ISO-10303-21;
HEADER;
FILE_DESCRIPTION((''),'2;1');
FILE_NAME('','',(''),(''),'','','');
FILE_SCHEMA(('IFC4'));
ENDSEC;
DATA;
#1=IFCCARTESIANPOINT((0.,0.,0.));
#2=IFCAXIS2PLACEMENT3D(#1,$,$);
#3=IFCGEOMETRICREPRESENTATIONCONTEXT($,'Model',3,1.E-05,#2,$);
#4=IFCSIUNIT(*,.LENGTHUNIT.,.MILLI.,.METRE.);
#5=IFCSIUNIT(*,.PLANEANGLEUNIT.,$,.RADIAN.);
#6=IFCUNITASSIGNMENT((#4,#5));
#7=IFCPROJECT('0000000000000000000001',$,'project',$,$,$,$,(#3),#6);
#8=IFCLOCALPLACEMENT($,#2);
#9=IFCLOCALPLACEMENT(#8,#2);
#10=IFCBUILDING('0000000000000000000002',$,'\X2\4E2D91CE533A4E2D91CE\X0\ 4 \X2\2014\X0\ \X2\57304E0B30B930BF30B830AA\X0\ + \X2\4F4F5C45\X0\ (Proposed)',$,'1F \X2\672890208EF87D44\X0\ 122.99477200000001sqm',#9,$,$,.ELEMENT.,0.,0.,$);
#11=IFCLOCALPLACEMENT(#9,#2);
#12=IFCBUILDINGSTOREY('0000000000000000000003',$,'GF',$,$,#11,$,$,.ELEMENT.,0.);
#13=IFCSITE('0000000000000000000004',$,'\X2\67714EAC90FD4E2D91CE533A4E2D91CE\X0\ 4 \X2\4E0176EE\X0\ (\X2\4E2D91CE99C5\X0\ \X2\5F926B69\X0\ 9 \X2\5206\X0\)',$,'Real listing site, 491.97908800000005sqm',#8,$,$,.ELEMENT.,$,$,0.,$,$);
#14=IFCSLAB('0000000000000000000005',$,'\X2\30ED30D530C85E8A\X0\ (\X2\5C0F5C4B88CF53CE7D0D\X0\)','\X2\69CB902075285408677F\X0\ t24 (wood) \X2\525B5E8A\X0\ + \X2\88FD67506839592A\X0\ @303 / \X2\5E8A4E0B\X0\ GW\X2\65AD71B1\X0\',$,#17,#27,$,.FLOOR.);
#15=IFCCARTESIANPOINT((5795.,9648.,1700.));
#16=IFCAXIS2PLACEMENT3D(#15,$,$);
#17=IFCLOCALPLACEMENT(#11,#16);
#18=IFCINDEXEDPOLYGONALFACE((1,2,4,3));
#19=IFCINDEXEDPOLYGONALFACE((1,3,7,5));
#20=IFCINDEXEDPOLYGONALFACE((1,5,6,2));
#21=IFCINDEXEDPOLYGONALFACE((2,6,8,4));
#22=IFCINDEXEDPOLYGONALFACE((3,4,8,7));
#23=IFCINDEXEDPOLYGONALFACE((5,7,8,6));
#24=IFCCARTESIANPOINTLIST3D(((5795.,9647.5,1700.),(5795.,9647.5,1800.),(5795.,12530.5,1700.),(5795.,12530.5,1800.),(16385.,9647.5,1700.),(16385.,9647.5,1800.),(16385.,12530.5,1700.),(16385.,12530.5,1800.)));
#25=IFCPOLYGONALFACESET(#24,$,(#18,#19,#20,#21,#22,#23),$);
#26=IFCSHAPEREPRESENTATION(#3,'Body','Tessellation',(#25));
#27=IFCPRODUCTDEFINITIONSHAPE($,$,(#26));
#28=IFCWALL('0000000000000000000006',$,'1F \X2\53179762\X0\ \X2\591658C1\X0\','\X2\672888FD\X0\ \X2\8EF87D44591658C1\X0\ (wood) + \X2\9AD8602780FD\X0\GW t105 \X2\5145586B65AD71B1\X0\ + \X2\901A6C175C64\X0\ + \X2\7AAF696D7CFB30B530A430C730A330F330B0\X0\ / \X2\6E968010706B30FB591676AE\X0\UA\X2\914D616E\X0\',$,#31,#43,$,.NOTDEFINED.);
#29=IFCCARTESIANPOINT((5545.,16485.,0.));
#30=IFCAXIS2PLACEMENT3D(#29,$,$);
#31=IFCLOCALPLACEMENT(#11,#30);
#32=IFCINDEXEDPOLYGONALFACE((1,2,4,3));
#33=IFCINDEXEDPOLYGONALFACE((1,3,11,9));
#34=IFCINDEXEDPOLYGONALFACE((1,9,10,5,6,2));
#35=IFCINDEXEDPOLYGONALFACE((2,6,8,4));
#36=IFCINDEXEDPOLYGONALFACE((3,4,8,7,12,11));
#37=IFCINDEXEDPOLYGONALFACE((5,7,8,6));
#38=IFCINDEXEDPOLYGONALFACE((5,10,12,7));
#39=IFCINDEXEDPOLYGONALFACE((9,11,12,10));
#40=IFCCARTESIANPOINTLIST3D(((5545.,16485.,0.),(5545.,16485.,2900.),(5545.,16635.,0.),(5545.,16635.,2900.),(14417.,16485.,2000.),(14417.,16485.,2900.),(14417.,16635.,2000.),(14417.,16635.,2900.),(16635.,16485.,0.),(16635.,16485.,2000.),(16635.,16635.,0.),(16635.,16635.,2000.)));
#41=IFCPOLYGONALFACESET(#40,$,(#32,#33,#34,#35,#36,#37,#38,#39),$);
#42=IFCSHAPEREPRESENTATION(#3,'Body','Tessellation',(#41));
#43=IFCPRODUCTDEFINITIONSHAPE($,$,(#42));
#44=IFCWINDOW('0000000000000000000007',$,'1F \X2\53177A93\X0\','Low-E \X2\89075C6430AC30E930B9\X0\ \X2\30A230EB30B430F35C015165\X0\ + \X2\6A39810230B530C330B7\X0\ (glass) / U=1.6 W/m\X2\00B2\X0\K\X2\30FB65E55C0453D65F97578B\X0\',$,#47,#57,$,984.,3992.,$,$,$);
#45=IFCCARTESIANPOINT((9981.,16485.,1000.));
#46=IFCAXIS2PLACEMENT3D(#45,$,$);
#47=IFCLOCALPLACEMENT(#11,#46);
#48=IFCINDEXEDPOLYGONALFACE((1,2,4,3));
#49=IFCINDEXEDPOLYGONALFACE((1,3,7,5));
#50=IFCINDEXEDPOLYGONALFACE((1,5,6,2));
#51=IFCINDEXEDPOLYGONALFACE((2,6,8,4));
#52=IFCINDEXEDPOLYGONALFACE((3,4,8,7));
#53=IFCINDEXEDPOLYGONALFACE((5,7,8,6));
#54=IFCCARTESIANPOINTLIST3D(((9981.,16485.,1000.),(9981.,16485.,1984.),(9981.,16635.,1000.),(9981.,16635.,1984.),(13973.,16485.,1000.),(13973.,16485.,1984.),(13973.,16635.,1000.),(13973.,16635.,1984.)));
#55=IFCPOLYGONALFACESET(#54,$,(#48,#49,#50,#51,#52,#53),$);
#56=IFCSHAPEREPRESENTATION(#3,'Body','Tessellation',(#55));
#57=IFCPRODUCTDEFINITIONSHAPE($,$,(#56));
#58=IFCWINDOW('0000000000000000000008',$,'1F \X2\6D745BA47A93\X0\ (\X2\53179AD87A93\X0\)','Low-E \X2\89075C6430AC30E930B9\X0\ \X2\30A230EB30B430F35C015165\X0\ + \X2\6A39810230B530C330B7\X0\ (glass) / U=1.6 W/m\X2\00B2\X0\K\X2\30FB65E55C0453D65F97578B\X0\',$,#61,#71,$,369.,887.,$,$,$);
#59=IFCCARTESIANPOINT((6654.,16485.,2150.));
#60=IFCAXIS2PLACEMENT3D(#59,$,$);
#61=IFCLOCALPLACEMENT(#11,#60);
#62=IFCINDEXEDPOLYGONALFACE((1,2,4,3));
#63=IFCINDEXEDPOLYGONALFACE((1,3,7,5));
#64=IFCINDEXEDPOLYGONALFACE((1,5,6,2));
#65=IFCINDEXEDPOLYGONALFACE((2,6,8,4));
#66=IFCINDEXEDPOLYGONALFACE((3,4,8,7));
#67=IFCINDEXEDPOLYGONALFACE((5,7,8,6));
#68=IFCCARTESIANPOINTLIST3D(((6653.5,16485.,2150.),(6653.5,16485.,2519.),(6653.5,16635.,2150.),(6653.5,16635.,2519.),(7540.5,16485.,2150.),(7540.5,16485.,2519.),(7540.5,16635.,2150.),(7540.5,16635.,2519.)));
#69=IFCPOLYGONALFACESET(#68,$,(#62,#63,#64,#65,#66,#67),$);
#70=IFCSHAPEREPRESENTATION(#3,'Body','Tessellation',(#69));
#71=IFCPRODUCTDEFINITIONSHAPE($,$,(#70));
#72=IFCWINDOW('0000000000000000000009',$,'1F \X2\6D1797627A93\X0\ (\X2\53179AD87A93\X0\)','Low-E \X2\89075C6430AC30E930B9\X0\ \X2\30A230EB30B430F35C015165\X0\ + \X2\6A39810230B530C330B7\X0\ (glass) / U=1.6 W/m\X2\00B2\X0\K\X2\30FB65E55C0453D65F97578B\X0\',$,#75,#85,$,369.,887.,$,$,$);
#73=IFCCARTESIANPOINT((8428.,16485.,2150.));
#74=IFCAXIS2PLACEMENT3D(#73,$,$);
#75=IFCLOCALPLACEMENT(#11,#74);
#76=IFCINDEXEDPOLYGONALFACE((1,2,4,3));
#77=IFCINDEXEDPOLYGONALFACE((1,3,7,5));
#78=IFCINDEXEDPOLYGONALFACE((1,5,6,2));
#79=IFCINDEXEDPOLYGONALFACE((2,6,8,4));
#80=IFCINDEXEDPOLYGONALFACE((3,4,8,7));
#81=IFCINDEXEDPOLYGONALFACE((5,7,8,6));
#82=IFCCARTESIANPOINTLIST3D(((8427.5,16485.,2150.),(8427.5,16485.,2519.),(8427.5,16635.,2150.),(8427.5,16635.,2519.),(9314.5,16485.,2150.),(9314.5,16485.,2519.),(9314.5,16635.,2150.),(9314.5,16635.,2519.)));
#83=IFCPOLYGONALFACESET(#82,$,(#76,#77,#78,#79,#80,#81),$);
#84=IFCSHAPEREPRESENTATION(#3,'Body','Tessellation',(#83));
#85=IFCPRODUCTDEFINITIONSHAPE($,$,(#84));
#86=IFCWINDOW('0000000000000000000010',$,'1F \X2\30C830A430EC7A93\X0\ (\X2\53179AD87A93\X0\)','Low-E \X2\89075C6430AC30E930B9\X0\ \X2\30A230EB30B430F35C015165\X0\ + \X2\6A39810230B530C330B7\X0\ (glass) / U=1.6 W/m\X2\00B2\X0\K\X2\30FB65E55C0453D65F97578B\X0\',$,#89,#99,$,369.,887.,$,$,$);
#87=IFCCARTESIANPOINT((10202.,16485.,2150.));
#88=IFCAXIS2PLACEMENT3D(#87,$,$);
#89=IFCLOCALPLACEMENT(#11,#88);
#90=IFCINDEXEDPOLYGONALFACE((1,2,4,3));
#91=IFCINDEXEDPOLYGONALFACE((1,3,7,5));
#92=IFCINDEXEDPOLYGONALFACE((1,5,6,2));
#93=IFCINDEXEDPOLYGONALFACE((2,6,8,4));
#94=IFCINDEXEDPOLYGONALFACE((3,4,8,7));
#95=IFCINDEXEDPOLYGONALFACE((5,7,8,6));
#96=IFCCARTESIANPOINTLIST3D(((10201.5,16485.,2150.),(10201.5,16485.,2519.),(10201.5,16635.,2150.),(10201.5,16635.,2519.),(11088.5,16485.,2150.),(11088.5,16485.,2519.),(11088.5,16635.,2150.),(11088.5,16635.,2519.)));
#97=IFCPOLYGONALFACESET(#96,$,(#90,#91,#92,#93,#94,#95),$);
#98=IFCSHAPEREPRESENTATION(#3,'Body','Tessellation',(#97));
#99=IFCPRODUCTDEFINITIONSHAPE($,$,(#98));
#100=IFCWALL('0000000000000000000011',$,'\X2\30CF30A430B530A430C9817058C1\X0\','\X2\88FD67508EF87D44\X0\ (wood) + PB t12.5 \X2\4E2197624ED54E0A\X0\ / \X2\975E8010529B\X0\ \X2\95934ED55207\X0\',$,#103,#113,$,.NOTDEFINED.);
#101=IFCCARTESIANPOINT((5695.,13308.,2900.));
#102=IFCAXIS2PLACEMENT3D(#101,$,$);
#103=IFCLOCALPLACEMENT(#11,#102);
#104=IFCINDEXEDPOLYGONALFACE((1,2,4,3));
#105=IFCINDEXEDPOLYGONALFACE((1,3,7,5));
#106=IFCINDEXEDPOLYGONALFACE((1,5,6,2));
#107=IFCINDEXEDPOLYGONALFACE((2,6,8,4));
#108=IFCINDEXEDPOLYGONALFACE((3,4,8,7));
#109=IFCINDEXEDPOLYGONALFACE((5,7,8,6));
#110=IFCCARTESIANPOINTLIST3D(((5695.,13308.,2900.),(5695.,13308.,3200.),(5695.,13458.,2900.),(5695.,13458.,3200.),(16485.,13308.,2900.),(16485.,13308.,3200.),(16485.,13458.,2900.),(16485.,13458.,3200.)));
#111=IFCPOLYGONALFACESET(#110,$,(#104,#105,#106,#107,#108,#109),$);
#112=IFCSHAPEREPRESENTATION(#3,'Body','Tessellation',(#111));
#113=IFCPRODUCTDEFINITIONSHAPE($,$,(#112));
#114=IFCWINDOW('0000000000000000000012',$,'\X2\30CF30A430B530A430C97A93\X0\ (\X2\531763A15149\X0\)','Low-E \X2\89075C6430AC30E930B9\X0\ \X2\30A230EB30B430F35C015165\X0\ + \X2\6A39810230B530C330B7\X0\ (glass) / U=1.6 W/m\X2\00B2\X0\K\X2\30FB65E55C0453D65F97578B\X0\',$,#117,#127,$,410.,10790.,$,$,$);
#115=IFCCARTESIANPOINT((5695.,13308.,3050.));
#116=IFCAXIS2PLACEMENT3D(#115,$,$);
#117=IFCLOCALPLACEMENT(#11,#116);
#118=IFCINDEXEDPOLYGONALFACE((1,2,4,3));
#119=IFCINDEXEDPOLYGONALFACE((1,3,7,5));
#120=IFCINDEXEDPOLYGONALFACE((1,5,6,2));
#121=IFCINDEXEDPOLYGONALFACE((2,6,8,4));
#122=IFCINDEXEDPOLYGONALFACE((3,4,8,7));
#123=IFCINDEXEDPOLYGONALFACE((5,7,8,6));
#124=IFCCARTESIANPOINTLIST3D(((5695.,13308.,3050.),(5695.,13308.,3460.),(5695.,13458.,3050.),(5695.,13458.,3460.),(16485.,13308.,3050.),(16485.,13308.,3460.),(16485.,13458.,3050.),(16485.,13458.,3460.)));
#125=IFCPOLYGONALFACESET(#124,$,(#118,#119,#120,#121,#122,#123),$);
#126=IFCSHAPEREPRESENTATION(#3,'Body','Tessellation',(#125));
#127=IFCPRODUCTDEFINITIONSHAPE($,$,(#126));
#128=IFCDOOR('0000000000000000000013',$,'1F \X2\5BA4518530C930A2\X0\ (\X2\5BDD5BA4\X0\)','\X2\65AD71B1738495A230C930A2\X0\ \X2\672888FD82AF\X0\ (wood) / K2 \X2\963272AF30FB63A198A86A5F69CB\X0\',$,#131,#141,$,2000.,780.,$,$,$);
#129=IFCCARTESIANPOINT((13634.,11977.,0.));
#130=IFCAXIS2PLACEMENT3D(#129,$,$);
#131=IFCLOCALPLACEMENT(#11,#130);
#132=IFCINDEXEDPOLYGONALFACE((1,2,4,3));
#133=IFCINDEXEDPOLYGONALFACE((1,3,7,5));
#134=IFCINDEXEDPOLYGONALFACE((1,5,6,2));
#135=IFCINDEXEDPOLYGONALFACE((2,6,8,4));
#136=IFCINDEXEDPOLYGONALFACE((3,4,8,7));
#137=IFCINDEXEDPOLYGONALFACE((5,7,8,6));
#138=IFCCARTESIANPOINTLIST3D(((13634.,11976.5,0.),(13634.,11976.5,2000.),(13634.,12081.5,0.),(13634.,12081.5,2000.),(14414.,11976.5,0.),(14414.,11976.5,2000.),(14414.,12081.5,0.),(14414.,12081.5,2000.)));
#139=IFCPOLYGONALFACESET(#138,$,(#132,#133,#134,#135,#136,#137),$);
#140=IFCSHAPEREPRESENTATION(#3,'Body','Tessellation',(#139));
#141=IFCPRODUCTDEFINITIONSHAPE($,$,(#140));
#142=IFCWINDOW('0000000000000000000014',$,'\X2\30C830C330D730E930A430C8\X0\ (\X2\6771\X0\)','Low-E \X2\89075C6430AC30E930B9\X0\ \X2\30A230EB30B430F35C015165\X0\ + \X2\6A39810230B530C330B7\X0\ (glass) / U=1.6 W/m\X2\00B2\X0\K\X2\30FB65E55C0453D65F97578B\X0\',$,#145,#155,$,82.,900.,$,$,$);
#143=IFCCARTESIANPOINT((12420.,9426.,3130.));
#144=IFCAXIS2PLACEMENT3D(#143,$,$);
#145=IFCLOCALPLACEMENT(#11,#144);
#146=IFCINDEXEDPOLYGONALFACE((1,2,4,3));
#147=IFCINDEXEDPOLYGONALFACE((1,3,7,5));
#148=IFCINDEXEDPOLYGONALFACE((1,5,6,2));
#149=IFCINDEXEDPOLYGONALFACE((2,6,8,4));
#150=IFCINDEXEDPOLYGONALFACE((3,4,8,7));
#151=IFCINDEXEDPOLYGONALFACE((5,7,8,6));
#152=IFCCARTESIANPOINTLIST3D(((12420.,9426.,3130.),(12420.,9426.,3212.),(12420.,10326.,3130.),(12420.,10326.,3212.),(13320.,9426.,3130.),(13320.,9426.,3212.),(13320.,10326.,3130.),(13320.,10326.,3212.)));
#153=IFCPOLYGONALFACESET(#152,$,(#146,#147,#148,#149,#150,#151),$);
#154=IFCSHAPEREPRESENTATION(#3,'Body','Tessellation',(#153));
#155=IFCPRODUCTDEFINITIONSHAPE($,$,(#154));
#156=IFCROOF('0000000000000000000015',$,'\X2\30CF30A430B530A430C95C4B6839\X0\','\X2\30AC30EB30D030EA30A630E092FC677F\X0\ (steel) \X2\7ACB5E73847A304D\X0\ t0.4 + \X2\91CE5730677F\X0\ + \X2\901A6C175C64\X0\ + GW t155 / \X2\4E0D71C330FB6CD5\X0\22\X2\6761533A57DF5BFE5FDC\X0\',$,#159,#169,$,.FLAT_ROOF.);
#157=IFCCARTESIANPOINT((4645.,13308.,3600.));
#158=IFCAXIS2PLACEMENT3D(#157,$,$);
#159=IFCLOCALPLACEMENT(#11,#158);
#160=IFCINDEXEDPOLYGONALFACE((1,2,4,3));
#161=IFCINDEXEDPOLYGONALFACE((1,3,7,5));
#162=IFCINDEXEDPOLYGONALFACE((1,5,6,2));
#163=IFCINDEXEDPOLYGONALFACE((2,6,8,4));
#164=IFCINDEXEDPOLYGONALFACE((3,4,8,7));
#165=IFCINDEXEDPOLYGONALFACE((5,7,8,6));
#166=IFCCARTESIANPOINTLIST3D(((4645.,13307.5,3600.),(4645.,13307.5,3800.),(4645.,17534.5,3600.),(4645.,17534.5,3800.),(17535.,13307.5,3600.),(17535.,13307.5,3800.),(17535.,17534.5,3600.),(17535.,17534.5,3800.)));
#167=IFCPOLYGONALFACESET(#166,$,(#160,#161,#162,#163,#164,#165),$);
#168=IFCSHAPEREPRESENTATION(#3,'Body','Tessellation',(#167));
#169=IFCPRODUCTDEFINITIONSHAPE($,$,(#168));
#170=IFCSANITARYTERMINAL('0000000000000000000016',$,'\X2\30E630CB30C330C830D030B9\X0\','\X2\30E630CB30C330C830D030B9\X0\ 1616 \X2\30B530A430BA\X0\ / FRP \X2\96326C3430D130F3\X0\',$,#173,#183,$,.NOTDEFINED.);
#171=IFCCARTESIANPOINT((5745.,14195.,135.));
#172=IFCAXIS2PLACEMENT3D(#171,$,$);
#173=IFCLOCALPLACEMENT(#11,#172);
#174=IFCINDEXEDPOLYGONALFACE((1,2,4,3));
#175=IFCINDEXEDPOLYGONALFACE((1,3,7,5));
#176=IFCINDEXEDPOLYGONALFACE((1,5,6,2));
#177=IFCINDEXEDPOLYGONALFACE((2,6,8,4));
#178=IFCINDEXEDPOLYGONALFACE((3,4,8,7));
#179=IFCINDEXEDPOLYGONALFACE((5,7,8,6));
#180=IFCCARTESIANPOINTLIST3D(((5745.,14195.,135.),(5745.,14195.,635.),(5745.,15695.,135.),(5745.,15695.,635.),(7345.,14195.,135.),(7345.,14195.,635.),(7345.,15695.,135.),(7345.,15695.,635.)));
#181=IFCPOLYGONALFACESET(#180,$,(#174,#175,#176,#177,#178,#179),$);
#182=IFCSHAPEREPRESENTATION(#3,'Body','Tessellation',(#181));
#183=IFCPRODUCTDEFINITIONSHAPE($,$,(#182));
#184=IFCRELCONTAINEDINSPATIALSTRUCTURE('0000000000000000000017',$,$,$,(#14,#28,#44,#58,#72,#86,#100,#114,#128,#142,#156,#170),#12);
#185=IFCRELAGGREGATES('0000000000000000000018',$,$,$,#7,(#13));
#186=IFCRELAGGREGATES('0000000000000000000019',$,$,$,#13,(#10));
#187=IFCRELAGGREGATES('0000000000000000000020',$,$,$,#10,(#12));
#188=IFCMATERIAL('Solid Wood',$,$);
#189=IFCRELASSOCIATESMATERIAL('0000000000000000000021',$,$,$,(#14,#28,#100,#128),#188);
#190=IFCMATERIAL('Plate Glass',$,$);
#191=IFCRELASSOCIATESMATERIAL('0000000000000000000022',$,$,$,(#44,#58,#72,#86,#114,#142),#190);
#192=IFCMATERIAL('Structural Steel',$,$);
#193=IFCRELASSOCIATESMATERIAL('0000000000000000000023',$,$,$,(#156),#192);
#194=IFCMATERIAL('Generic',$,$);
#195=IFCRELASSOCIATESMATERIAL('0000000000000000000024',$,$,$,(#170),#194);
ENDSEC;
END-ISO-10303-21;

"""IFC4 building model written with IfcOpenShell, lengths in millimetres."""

from ifc_helpers import new_model, si_unit, frame, frame_2d, origin, place, context, project, spatial, rectangle, extrude, material, element, fill, save


model = new_model("IFC4")

# Units and contexts
model_context = context("Model", 3, precision=1e-05, world=origin())
ifc_project = project(units=[si_unit("LENGTHUNIT", "METRE", prefix="MILLI"), si_unit("PLANEANGLEUNIT", "RADIAN")], contexts=[model_context])

# Site, building, storey
site_placement = place(None, origin())
site = spatial("IfcSite", under=ifc_project, at=site_placement, Name="東京都中野区中野 4 丁目 (中野駅 徒歩 9 分)", ObjectType="Real listing site, 491.97908800000005sqm", CompositionType="ELEMENT", RefElevation=0.0)
building_placement = place(site_placement, origin())
building = spatial("IfcBuilding", under=site, at=building_placement, Name="中野区中野 4 — 地下スタジオ + 住居 (Proposed)", ObjectType="1F 木造軸組 122.99477200000001sqm", CompositionType="ELEMENT", ElevationOfRefHeight=0.0, ElevationOfTerrain=0.0)
storey_placement = place(building_placement, origin())
storey = spatial("IfcBuildingStorey", under=building, at=storey_placement, Name="GF", CompositionType="ELEMENT", Elevation=0.0)

# Slab
ifc_material_1 = material(Name="Solid Wood")
slab_placement = place(storey_placement, frame((5795.0, 9648.0, 1700.0)))
element("IfcSlab", 1, at=slab_placement, inside=storey, material=ifc_material_1, Name="ロフト床 (小屋裏収納)", Description="構造用合板 t24 (wood) 剛床 + 製材根太 @303 / 床下 GW断熱", PredefinedType="FLOOR", context=model_context, shape_type="SweptSolid", body=[
    extrude(rectangle(XDim=10590.0, YDim=2883.0, at=frame_2d((5295.0, 1441.0))), frame((5795.0, 9648.0, 1700.0)), (0.0, 0.0, 1.0), 100.0),
])

# Wall, openings, windows
wall_1_placement = place(storey_placement, frame((5545.0, 16485.0, 0.0)))
wall_1 = element("IfcWall", 2, at=wall_1_placement, inside=storey, material=ifc_material_1, Name="1F 北面 外壁", Description="木製 軸組外壁 (wood) + 高性能GW t105 充填断熱 + 通気層 + 窯業系サイディング / 準耐火・外皮UA配慮", PredefinedType="NOTDEFINED", context=model_context, shape_type="SweptSolid", body=[
    extrude(rectangle(XDim=11090.0, YDim=150.0, at=frame_2d((5545.0, 75.0))), frame((5545.0, 16485.0, 0.0)), (0.0, 0.0, 1.0), 2900.0),
])
opening_1_placement = place(storey_placement, frame((9981.0, 16485.0, 1000.0)))
opening_1 = element("IfcOpeningElement", 3, at=opening_1_placement, cuts=wall_1, PredefinedType="NOTDEFINED", context=model_context, shape_type="SweptSolid", body=[
    extrude(rectangle(XDim=3992.0, YDim=150.0, at=frame_2d((1996.0, 75.0))), frame((9981.0, 16485.0, 1000.0)), (0.0, 0.0, 1.0), 984.0),
])
opening_2_placement = place(storey_placement, frame((6654.0, 16485.0, 2150.0)))
opening_2 = element("IfcOpeningElement", 4, at=opening_2_placement, cuts=wall_1, PredefinedType="NOTDEFINED", context=model_context, shape_type="SweptSolid", body=[
    extrude(rectangle(XDim=887.0, YDim=150.0, at=frame_2d((443.0, 75.0))), frame((6654.0, 16485.0, 2150.0)), (0.0, 0.0, 1.0), 369.0),
])
opening_3_placement = place(storey_placement, frame((8428.0, 16485.0, 2150.0)))
opening_3 = element("IfcOpeningElement", 5, at=opening_3_placement, cuts=wall_1, PredefinedType="NOTDEFINED", context=model_context, shape_type="SweptSolid", body=[
    extrude(rectangle(XDim=887.0, YDim=150.0, at=frame_2d((443.0, 75.0))), frame((8428.0, 16485.0, 2150.0)), (0.0, 0.0, 1.0), 369.0),
])
opening_4_placement = place(storey_placement, frame((10202.0, 16485.0, 2150.0)))
opening_4 = element("IfcOpeningElement", 6, at=opening_4_placement, cuts=wall_1, PredefinedType="NOTDEFINED", context=model_context, shape_type="SweptSolid", body=[
    extrude(rectangle(XDim=887.0, YDim=150.0, at=frame_2d((443.0, 75.0))), frame((10202.0, 16485.0, 2150.0)), (0.0, 0.0, 1.0), 369.0),
])
ifc_material_2 = material(Name="Plate Glass")
window_1_placement = place(storey_placement, frame((9981.0, 16485.0, 1000.0)))
window_1 = element("IfcWindow", 7, at=window_1_placement, inside=storey, material=ifc_material_2, Name="1F 北窓", Description="Low-E 複層ガラス アルゴン封入 + 樹脂サッシ (glass) / U=1.6 W/m²K・日射取得型", OverallHeight=984.0, OverallWidth=3992.0, context=model_context, shape_type="SweptSolid", body=[
    extrude(rectangle(XDim=3992.0, YDim=150.0, at=frame_2d((1996.0, 75.0))), frame((9981.0, 16485.0, 1000.0)), (0.0, 0.0, 1.0), 984.0),
])
fill(opening_1, window_1)
window_2_placement = place(storey_placement, frame((6654.0, 16485.0, 2150.0)))
window_2 = element("IfcWindow", 8, at=window_2_placement, inside=storey, material=ifc_material_2, Name="1F 浴室窓 (北高窓)", Description="Low-E 複層ガラス アルゴン封入 + 樹脂サッシ (glass) / U=1.6 W/m²K・日射取得型", OverallHeight=369.0, OverallWidth=887.0, context=model_context, shape_type="SweptSolid", body=[
    extrude(rectangle(XDim=887.0, YDim=150.0, at=frame_2d((443.0, 75.0))), frame((6654.0, 16485.0, 2150.0)), (0.0, 0.0, 1.0), 369.0),
])
fill(opening_2, window_2)
window_3_placement = place(storey_placement, frame((8428.0, 16485.0, 2150.0)))
window_3 = element("IfcWindow", 9, at=window_3_placement, inside=storey, material=ifc_material_2, Name="1F 洗面窓 (北高窓)", Description="Low-E 複層ガラス アルゴン封入 + 樹脂サッシ (glass) / U=1.6 W/m²K・日射取得型", OverallHeight=369.0, OverallWidth=887.0, context=model_context, shape_type="SweptSolid", body=[
    extrude(rectangle(XDim=887.0, YDim=150.0, at=frame_2d((443.0, 75.0))), frame((8428.0, 16485.0, 2150.0)), (0.0, 0.0, 1.0), 369.0),
])
fill(opening_3, window_3)
window_4_placement = place(storey_placement, frame((10202.0, 16485.0, 2150.0)))
window_4 = element("IfcWindow", 10, at=window_4_placement, inside=storey, material=ifc_material_2, Name="1F トイレ窓 (北高窓)", Description="Low-E 複層ガラス アルゴン封入 + 樹脂サッシ (glass) / U=1.6 W/m²K・日射取得型", OverallHeight=369.0, OverallWidth=887.0, context=model_context, shape_type="SweptSolid", body=[
    extrude(rectangle(XDim=887.0, YDim=150.0, at=frame_2d((443.0, 75.0))), frame((10202.0, 16485.0, 2150.0)), (0.0, 0.0, 1.0), 369.0),
])
fill(opening_4, window_4)

# Wall, opening, window
wall_2_placement = place(storey_placement, frame((5695.0, 13308.0, 2900.0)))
wall_2 = element("IfcWall", 11, at=wall_2_placement, inside=storey, material=ifc_material_1, Name="ハイサイド腰壁", Description="製材軸組 (wood) + PB t12.5 両面仕上 / 非耐力 間仕切", PredefinedType="NOTDEFINED", context=model_context, shape_type="SweptSolid", body=[
    extrude(rectangle(XDim=10790.0, YDim=150.0, at=frame_2d((5395.0, 75.0))), frame((5695.0, 13308.0, 2900.0)), (0.0, 0.0, 1.0), 700.0),
])
opening_5_placement = place(storey_placement, frame((5695.0, 13308.0, 3050.0)))
opening_5 = element("IfcOpeningElement", 12, at=opening_5_placement, cuts=wall_2, PredefinedType="NOTDEFINED", context=model_context, shape_type="SweptSolid", body=[
    extrude(rectangle(XDim=10790.0, YDim=150.0, at=frame_2d((5395.0, 75.0))), frame((5695.0, 13308.0, 3050.0)), (0.0, 0.0, 1.0), 410.0),
])
window_5_placement = place(storey_placement, frame((5695.0, 13308.0, 3050.0)))
window_5 = element("IfcWindow", 13, at=window_5_placement, inside=storey, material=ifc_material_2, Name="ハイサイド窓 (北採光)", Description="Low-E 複層ガラス アルゴン封入 + 樹脂サッシ (glass) / U=1.6 W/m²K・日射取得型", OverallHeight=410.0, OverallWidth=10790.0, context=model_context, shape_type="SweptSolid", body=[
    extrude(rectangle(XDim=10790.0, YDim=150.0, at=frame_2d((5395.0, 75.0))), frame((5695.0, 13308.0, 3050.0)), (0.0, 0.0, 1.0), 410.0),
])
fill(opening_5, window_5)

# Door
door_1_placement = place(storey_placement, frame((13634.0, 11977.0, 0.0)))
element("IfcDoor", 14, at=door_1_placement, inside=storey, material=ifc_material_1, Name="1F 室内ドア (寝室)", Description="断熱玄関ドア 木製芯 (wood) / K2 防犯・採風機構", OverallHeight=2000.0, OverallWidth=780.0, context=model_context, shape_type="SweptSolid", body=[
    extrude(rectangle(XDim=780.0, YDim=105.0, at=frame_2d((390.0, 52.0))), frame((13634.0, 11977.0, 0.0)), (0.0, 0.0, 1.0), 2000.0),
])

# Window
window_6_placement = place(storey_placement, frame((12420.0, 9426.0, 3130.0)))
element("IfcWindow", 15, at=window_6_placement, inside=storey, material=ifc_material_2, Name="トップライト (東)", Description="Low-E 複層ガラス アルゴン封入 + 樹脂サッシ (glass) / U=1.6 W/m²K・日射取得型", OverallHeight=82.0, OverallWidth=900.0, context=model_context, shape_type="SweptSolid", body=[
    extrude(rectangle(XDim=900.0, YDim=900.0, at=frame_2d((450.0, 450.0))), frame((12420.0, 9426.0, 3130.0)), (0.0, 0.0, 1.0), 82.0),
])

# Roof
ifc_material_3 = material(Name="Structural Steel")
roof_placement = place(storey_placement, frame((4645.0, 13308.0, 3600.0)))
element("IfcRoof", 16, at=roof_placement, inside=storey, material=ifc_material_3, Name="ハイサイド屋根", Description="ガルバリウム鋼板 (steel) 立平葺き t0.4 + 野地板 + 通気層 + GW t155 / 不燃・法22条区域対応", PredefinedType="FLAT_ROOF", context=model_context, shape_type="SweptSolid", body=[
    extrude(rectangle(XDim=12890.0, YDim=4227.0, at=frame_2d((6445.0, 2113.0))), frame((4645.0, 13308.0, 3600.0)), (0.0, 0.0, 1.0), 200.0),
])

# Sanitary terminal
ifc_material_4 = material(Name="Generic")
sanitary_terminal_1_placement = place(storey_placement, frame((5745.0, 14195.0, 135.0)))
element("IfcSanitaryTerminal", 17, at=sanitary_terminal_1_placement, inside=storey, material=ifc_material_4, Name="ユニットバス", Description="ユニットバス 1616 サイズ / FRP 防水パン", PredefinedType="NOTDEFINED", context=model_context, shape_type="SweptSolid", body=[
    extrude(rectangle(XDim=1600.0, YDim=1500.0, at=frame_2d((800.0, 750.0))), frame((5745.0, 14195.0, 135.0)), (0.0, 0.0, 1.0), 500.0),
])

save(model, "model.ifc")
